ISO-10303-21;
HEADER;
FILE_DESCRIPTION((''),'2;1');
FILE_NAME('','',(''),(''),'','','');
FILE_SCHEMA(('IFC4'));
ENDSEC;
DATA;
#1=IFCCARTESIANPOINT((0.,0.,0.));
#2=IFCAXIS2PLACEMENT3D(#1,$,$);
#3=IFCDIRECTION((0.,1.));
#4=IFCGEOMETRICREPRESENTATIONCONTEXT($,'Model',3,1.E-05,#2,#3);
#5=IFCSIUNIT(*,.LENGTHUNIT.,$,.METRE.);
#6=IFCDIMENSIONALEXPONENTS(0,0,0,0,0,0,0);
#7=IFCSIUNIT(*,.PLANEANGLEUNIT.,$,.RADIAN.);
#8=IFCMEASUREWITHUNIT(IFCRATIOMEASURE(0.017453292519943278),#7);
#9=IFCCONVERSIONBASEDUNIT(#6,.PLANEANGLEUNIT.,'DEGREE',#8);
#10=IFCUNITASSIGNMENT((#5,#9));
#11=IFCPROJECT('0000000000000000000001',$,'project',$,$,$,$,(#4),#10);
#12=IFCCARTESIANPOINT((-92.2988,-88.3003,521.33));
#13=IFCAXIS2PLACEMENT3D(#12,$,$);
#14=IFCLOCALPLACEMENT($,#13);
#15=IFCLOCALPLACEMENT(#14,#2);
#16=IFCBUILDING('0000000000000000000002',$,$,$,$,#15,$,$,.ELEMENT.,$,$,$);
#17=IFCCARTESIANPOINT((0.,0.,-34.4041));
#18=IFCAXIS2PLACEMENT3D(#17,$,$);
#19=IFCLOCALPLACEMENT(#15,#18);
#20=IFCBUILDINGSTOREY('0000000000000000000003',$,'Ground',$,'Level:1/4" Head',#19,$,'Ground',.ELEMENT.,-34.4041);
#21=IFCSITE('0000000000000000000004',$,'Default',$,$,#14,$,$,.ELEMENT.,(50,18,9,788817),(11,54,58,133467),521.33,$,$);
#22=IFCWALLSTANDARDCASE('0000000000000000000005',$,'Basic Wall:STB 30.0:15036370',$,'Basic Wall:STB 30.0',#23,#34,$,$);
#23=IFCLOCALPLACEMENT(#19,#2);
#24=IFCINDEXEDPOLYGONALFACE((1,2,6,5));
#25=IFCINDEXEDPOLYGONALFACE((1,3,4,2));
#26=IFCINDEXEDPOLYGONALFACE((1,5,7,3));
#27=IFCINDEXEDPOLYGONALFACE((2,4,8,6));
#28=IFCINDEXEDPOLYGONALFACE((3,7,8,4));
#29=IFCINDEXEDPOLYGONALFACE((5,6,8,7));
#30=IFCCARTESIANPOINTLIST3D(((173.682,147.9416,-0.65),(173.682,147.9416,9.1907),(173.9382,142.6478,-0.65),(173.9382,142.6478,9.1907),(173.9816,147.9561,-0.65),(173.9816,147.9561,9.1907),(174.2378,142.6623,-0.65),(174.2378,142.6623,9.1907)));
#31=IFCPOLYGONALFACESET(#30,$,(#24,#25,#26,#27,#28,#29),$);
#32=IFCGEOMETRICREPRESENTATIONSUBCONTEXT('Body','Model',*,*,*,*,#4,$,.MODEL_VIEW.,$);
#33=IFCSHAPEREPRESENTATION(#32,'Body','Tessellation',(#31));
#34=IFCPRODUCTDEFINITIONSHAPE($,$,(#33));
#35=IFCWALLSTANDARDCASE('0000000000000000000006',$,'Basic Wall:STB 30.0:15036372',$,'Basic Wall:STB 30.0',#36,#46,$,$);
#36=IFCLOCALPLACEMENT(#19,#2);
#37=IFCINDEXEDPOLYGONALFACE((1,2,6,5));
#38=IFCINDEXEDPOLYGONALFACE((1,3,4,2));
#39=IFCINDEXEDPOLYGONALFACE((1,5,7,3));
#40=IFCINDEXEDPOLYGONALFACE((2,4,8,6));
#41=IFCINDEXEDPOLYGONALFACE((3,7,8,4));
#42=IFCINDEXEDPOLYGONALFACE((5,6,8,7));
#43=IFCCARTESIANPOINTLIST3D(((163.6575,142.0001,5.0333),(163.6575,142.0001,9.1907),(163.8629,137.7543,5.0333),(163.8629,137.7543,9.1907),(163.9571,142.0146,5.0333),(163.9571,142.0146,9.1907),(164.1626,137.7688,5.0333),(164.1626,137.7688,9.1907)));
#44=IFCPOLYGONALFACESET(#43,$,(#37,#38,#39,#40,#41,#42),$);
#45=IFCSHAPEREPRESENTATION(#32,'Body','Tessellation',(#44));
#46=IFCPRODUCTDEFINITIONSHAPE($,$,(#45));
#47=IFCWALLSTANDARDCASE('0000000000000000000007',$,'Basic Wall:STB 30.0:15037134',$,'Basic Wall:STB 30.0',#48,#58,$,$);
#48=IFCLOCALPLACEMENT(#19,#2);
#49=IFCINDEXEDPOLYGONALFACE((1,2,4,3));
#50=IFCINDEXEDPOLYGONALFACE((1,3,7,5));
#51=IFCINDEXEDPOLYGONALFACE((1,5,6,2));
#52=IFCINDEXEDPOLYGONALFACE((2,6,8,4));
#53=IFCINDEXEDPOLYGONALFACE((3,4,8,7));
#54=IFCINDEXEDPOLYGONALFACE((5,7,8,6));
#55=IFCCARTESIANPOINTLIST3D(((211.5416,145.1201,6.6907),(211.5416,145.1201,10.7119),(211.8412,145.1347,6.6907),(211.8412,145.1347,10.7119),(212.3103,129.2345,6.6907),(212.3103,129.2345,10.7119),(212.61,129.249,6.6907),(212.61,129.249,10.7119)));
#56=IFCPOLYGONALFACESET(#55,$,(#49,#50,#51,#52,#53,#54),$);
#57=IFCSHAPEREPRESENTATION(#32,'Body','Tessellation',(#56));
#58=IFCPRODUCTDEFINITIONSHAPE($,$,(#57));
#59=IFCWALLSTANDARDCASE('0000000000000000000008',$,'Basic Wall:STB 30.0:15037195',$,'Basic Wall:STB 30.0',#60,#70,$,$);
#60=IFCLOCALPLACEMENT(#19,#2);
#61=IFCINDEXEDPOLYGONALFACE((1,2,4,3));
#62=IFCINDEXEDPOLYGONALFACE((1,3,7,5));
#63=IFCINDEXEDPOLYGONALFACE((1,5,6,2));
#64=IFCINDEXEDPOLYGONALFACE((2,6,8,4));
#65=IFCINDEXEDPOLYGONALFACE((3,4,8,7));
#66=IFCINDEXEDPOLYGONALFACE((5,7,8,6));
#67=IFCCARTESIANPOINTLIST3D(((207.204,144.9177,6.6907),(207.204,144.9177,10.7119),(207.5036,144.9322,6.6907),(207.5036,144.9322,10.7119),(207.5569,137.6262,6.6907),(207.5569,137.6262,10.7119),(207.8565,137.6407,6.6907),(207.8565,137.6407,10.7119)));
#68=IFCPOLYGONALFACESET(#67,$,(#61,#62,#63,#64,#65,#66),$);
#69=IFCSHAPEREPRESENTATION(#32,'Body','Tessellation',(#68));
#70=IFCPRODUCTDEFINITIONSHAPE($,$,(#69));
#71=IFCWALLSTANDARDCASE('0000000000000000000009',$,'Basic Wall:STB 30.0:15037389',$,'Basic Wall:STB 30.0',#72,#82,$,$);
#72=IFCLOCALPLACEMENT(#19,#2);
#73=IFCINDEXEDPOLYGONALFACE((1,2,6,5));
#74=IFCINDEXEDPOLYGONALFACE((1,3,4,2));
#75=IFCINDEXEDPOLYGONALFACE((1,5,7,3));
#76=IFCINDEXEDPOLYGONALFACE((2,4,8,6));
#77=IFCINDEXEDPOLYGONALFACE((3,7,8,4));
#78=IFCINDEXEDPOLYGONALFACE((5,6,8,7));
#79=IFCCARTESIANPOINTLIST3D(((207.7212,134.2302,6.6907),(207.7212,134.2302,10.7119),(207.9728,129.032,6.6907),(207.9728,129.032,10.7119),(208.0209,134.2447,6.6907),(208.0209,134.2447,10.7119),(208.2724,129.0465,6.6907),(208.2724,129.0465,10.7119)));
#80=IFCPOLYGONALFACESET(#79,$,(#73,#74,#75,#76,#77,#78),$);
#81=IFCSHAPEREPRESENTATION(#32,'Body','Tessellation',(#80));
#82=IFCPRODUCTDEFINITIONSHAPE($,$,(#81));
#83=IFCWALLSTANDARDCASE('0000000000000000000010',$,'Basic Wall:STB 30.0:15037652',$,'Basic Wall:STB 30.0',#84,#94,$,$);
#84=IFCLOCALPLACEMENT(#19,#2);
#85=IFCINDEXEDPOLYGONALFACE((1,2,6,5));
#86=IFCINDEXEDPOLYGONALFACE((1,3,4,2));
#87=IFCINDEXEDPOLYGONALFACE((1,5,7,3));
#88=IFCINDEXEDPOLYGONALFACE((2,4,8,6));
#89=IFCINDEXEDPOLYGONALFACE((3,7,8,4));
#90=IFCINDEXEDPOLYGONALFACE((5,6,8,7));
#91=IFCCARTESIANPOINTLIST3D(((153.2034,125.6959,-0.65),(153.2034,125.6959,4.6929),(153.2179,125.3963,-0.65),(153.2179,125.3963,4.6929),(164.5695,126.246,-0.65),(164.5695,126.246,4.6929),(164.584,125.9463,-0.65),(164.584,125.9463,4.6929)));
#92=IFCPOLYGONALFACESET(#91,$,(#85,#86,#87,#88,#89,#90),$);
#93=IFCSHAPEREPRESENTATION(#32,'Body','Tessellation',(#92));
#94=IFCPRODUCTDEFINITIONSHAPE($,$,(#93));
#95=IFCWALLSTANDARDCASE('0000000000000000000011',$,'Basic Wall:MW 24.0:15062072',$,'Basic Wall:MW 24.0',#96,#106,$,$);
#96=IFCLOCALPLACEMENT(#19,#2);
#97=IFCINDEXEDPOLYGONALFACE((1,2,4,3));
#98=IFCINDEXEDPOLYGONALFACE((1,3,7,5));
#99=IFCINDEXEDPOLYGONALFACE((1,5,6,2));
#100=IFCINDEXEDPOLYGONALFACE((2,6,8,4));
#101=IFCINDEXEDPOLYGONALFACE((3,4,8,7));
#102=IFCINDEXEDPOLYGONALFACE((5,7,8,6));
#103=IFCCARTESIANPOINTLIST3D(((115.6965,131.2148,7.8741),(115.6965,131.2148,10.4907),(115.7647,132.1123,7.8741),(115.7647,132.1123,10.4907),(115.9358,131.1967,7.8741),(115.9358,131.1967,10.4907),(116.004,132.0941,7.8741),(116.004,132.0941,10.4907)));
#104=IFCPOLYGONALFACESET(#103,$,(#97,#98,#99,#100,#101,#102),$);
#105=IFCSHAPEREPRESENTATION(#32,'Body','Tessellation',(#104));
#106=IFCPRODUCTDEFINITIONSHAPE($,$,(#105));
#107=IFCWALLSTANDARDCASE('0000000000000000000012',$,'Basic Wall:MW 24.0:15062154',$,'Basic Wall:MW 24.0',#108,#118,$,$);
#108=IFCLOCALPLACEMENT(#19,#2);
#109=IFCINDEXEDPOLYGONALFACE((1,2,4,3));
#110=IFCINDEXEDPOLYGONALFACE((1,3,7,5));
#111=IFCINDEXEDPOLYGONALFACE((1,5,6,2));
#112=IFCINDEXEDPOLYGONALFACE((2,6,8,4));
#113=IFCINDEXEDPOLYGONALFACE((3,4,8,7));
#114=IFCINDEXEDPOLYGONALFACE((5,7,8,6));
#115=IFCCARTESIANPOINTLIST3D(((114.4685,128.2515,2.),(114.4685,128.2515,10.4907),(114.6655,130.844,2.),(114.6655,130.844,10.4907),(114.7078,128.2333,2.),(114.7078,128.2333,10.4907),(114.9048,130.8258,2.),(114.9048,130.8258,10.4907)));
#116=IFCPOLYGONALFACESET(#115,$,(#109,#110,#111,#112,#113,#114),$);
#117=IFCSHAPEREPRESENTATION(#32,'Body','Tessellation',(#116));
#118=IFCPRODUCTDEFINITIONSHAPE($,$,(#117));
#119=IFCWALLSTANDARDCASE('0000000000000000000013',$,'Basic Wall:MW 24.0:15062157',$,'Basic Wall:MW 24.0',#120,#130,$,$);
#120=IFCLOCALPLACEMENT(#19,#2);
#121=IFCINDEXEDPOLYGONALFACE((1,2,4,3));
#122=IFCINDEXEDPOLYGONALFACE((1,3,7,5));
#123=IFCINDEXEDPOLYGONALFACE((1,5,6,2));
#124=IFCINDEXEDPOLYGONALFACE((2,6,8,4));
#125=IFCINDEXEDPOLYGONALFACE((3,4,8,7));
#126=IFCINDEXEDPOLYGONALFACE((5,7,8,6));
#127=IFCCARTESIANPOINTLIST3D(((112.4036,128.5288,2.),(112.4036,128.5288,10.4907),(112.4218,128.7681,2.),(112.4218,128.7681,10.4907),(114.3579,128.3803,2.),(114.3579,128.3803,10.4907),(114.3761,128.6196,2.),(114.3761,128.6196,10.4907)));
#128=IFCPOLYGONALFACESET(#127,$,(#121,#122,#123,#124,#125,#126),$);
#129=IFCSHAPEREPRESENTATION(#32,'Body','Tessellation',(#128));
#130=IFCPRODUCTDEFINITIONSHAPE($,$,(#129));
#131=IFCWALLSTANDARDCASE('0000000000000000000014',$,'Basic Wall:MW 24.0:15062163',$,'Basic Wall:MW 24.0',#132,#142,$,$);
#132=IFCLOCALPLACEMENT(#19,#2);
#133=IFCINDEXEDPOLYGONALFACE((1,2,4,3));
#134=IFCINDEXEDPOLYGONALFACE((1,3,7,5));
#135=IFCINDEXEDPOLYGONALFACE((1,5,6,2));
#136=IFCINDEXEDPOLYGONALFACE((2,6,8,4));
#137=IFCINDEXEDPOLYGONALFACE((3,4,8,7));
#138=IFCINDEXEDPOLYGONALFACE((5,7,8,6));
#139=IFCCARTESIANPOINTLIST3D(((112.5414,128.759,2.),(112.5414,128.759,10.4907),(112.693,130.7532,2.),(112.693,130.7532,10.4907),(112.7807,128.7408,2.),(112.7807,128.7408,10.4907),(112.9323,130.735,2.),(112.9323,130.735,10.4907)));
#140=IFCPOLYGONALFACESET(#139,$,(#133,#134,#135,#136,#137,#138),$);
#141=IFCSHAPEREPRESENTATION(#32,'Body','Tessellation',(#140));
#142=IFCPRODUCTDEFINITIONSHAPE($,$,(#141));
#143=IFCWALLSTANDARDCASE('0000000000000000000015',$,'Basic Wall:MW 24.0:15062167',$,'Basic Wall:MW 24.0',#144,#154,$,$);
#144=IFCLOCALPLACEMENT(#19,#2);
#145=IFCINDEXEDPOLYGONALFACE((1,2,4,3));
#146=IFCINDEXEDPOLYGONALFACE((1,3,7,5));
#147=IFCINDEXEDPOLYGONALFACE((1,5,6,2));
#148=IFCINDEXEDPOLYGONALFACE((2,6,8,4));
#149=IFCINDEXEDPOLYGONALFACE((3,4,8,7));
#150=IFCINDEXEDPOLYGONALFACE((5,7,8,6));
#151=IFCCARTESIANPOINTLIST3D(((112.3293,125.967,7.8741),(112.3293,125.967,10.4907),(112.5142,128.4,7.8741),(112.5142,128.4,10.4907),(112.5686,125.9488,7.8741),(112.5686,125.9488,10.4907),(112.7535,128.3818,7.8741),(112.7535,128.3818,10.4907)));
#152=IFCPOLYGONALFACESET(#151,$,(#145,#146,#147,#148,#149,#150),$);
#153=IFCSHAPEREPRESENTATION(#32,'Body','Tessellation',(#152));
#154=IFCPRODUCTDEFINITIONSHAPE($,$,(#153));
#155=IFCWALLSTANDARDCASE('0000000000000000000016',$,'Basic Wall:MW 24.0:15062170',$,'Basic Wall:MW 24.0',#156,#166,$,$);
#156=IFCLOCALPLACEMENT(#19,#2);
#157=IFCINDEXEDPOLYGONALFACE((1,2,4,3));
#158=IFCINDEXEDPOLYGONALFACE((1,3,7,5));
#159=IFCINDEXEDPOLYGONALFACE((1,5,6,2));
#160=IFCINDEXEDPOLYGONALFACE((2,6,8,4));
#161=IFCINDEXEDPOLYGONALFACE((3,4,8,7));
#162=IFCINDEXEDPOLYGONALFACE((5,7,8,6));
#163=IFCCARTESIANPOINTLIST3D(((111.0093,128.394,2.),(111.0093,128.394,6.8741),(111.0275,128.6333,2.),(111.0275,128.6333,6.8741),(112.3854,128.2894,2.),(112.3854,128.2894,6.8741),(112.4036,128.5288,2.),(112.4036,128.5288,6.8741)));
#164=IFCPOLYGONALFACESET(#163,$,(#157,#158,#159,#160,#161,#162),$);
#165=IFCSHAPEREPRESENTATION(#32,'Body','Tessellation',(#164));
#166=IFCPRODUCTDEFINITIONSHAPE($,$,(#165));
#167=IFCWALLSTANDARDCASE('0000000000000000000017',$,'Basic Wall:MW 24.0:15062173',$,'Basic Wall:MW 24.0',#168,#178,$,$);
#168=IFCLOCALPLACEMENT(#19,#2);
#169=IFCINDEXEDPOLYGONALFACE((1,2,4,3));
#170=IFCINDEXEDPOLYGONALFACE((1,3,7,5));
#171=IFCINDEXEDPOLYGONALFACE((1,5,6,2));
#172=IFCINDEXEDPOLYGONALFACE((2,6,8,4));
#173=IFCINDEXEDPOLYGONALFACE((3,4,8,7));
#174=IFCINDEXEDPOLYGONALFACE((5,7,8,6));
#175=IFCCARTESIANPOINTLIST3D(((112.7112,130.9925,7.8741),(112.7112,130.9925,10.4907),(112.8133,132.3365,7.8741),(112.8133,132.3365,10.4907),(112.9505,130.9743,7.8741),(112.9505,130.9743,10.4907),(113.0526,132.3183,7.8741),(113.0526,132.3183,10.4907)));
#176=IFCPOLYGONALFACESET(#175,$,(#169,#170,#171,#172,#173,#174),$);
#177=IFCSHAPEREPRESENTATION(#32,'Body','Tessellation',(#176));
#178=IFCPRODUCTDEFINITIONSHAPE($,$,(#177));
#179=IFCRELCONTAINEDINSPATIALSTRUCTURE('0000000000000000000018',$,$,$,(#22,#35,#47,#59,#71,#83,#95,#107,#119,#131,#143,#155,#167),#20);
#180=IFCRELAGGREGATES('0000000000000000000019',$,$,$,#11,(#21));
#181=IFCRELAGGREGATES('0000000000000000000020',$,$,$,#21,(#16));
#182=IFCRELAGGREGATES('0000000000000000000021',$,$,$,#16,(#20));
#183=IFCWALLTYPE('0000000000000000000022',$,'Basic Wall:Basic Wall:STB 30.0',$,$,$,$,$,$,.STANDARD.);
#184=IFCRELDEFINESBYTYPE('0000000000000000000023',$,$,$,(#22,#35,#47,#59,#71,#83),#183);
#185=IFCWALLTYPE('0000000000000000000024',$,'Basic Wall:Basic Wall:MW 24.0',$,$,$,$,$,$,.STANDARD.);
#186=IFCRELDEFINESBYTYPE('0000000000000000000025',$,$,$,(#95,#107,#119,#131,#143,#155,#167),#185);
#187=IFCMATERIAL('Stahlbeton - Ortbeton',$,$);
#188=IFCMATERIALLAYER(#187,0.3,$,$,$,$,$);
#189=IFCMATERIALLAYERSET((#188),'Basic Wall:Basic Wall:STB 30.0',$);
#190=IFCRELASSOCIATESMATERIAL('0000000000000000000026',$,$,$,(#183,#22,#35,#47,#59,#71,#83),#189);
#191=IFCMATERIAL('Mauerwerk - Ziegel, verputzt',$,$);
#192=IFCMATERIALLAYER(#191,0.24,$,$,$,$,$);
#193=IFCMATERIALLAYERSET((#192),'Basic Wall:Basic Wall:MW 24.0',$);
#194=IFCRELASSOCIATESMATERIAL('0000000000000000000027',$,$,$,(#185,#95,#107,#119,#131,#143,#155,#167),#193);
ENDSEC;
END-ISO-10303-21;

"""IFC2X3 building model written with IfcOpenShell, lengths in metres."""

from ifc_helpers import new_model, entity, si_unit, converted_unit, direction, frame, frame_2d, origin, place, context, subcontext, project, spatial, rectangle, extrude, material, layer, layer_set, layer_usage, type_object, element, save


model = new_model("IFC2X3")

# Units and contexts
model_context = context("Model", 3, precision=1e-05, world=origin(), true_north=direction((0.0, 1.0)))
body_context = subcontext(model_context, "Body", "Model", "MODEL_VIEW")
ifc_project = project(units=[si_unit("LENGTHUNIT", "METRE"), converted_unit("PLANEANGLEUNIT", "DEGREE", entity("IfcRatioMeasure", 0.017453292519943278), si_unit("PLANEANGLEUNIT", "RADIAN"), dimensions=[0, 0, 0, 0, 0, 0, 0])], contexts=[model_context])

# Site, building, storey
site_placement = place(None, frame((-92.2988, -88.3003, 521.33)))
site = spatial("IfcSite", under=ifc_project, at=site_placement, Name="Default", CompositionType="ELEMENT", RefLatitude=(50, 18, 9, 788817), RefLongitude=(11, 54, 58, 133467), RefElevation=521.33)
building_placement = place(site_placement, origin())
building = spatial("IfcBuilding", under=site, at=building_placement, CompositionType="ELEMENT")
storey_placement = place(building_placement, frame((0.0, 0.0, -34.4041)))
storey = spatial("IfcBuildingStorey", under=building, at=storey_placement, Name="Ground", ObjectType="Level:1/4\" Head", LongName="Ground", CompositionType="ELEMENT", Elevation=-34.4041)

# Walls
ifc_material_1 = material(Name="Stahlbeton - Ortbeton")
ifc_layer_1 = layer(ifc_material_1, 0.3)
ifc_layer_set_1 = layer_set([ifc_layer_1], Name="Basic Wall:Basic Wall:STB 30.0")
wall_type_1 = type_object("IfcWallType", Name="Basic Wall:Basic Wall:STB 30.0", PredefinedType="STANDARD", material=ifc_layer_set_1)
ifc_layer_usage_1 = layer_usage(ifc_layer_set_1, "AXIS2", "NEGATIVE", 0.15)
wall_1_placement = place(storey_placement, frame((173.8318, 147.9489, -0.65), z_axis=(0.0, 0.0, 1.0), x_axis=(0.048337, -0.998831, 0.0)))
element("IfcWallStandardCase", 1, at=wall_1_placement, inside=storey, type_object=wall_type_1, material=ifc_layer_usage_1, Name="Basic Wall:STB 30.0:15036370", ObjectType="Basic Wall:STB 30.0", context=body_context, shape_type="SweptSolid", body=[
    extrude(rectangle(XDim=5.3, YDim=0.3, at=frame_2d((2.65, 0.0), x_axis=(-1.0, 0.0))), origin(), (0.0, 0.0, 1.0), 9.8407),
])
ifc_layer_usage_2 = layer_usage(ifc_layer_set_1, "AXIS2", "NEGATIVE", 0.15)
wall_2_placement = place(storey_placement, frame((163.8073, 142.0074, 5.0333), z_axis=(0.0, 0.0, 1.0), x_axis=(0.048337, -0.998831, 0.0)))
element("IfcWallStandardCase", 2, at=wall_2_placement, inside=storey, type_object=wall_type_1, material=ifc_layer_usage_2, Name="Basic Wall:STB 30.0:15036372", ObjectType="Basic Wall:STB 30.0", context=body_context, shape_type="SweptSolid", body=[
    extrude(rectangle(XDim=4.2508, YDim=0.3, at=frame_2d((2.1254, 0.0), x_axis=(-1.0, 0.0))), origin(), (0.0, 0.0, 1.0), 4.1574),
])
ifc_layer_usage_3 = layer_usage(ifc_layer_set_1, "AXIS2", "NEGATIVE", 0.15)
wall_3_placement = place(storey_placement, frame((211.6914, 145.1274, 6.6907), z_axis=(0.0, 0.0, 1.0), x_axis=(0.048337, -0.998831, 0.0)))
element("IfcWallStandardCase", 3, at=wall_3_placement, inside=storey, type_object=wall_type_1, material=ifc_layer_usage_3, Name="Basic Wall:STB 30.0:15037134", ObjectType="Basic Wall:STB 30.0", context=body_context, shape_type="SweptSolid", body=[
    extrude(rectangle(XDim=15.9043, YDim=0.3, at=frame_2d((7.9521, 0.0), x_axis=(-1.0, 0.0))), origin(), (0.0, 0.0, 1.0), 4.0212),
])
ifc_layer_usage_4 = layer_usage(ifc_layer_set_1, "AXIS2", "NEGATIVE", 0.15)
wall_4_placement = place(storey_placement, frame((207.3538, 144.9249, 6.6907), z_axis=(0.0, 0.0, 1.0), x_axis=(0.048337, -0.998831, 0.0)))
element("IfcWallStandardCase", 4, at=wall_4_placement, inside=storey, type_object=wall_type_1, material=ifc_layer_usage_4, Name="Basic Wall:STB 30.0:15037195", ObjectType="Basic Wall:STB 30.0", context=body_context, shape_type="SweptSolid", body=[
    extrude(rectangle(XDim=7.3, YDim=0.3, at=frame_2d((3.65, 0.0), x_axis=(-1.0, 0.0))), origin(), (0.0, 0.0, 1.0), 4.0212),
])
ifc_layer_usage_5 = layer_usage(ifc_layer_set_1, "AXIS2", "NEGATIVE", 0.15)
wall_5_placement = place(storey_placement, frame((207.871, 134.2374, 6.6907), z_axis=(0.0, 0.0, 1.0), x_axis=(0.048337, -0.998831, 0.0)))
element("IfcWallStandardCase", 5, at=wall_5_placement, inside=storey, type_object=wall_type_1, material=ifc_layer_usage_5, Name="Basic Wall:STB 30.0:15037389", ObjectType="Basic Wall:STB 30.0", context=body_context, shape_type="SweptSolid", body=[
    extrude(rectangle(XDim=5.2043, YDim=0.3, at=frame_2d((2.6021, 0.0), x_axis=(-1.0, 0.0))), origin(), (0.0, 0.0, 1.0), 4.0212),
])
ifc_layer_usage_6 = layer_usage(ifc_layer_set_1, "AXIS2", "NEGATIVE", 0.15)
wall_6_placement = place(storey_placement, frame((164.5768, 126.0962, -0.65), z_axis=(0.0, 0.0, 1.0), x_axis=(-0.998831, -0.048337, 0.0)))
element("IfcWallStandardCase", 6, at=wall_6_placement, inside=storey, type_object=wall_type_1, material=ifc_layer_usage_6, Name="Basic Wall:STB 30.0:15037652", ObjectType="Basic Wall:STB 30.0", context=body_context, shape_type="SweptSolid", body=[
    extrude(rectangle(XDim=11.3795, YDim=0.3, at=frame_2d((5.6897, 0.0), x_axis=(-1.0, 0.0))), origin(), (0.0, 0.0, 1.0), 5.3429),
])
ifc_material_2 = material(Name="Mauerwerk - Ziegel, verputzt")
ifc_layer_2 = layer(ifc_material_2, 0.24)
ifc_layer_set_2 = layer_set([ifc_layer_2], Name="Basic Wall:Basic Wall:MW 24.0")
ifc_layer_usage_7 = layer_usage(ifc_layer_set_2, "AXIS2", "NEGATIVE", 0.12)
wall_type_2 = type_object("IfcWallType", Name="Basic Wall:Basic Wall:MW 24.0", PredefinedType="STANDARD", material=ifc_layer_set_2)
wall_7_placement = place(storey_placement, frame((115.8844, 132.1032, 7.8741), z_axis=(0.0, 0.0, 1.0), x_axis=(-0.07577, -0.997125, 0.0)))
element("IfcWallStandardCase", 7, at=wall_7_placement, inside=storey, type_object=wall_type_2, material=ifc_layer_usage_7, Name="Basic Wall:MW 24.0:15062072", ObjectType="Basic Wall:MW 24.0", context=body_context, shape_type="SweptSolid", body=[
    extrude(rectangle(XDim=0.9, YDim=0.24, at=frame_2d((0.45, 0.0), x_axis=(-1.0, 0.0))), origin(), (0.0, 0.0, 1.0), 2.6166),
])
ifc_layer_usage_8 = layer_usage(ifc_layer_set_2, "AXIS2", "NEGATIVE", 0.12)
wall_8_placement = place(storey_placement, frame((114.5881, 128.2424, 2.0), z_axis=(0.0, 0.0, 1.0), x_axis=(0.07577, 0.997125, 0.0)))
element("IfcWallStandardCase", 8, at=wall_8_placement, inside=storey, type_object=wall_type_2, material=ifc_layer_usage_8, Name="Basic Wall:MW 24.0:15062154", ObjectType="Basic Wall:MW 24.0", context=body_context, shape_type="SweptSolid", body=[
    extrude(rectangle(XDim=2.6, YDim=0.24, at=frame_2d((1.3, 0.0), x_axis=(-1.0, 0.0))), origin(), (0.0, 0.0, 1.0), 8.4907),
])
ifc_layer_usage_9 = layer_usage(ifc_layer_set_2, "AXIS2", "NEGATIVE", 0.12)
wall_9_placement = place(storey_placement, frame((114.367, 128.4999, 2.0), z_axis=(0.0, 0.0, 1.0), x_axis=(-0.997125, 0.07577, 0.0)))
element("IfcWallStandardCase", 9, at=wall_9_placement, inside=storey, type_object=wall_type_2, material=ifc_layer_usage_9, Name="Basic Wall:MW 24.0:15062157", ObjectType="Basic Wall:MW 24.0", context=body_context, shape_type="SweptSolid", body=[
    extrude(rectangle(XDim=1.9599, YDim=0.24, at=frame_2d((0.98, 0.0), x_axis=(-1.0, 0.0))), origin(), (0.0, 0.0, 1.0), 8.4907),
])
ifc_layer_usage_10 = layer_usage(ifc_layer_set_2, "AXIS2", "NEGATIVE", 0.12)
wall_10_placement = place(storey_placement, frame((112.6611, 128.7499, 2.0), z_axis=(0.0, 0.0, 1.0), x_axis=(0.07577, 0.997125, 0.0)))
element("IfcWallStandardCase", 10, at=wall_10_placement, inside=storey, type_object=wall_type_2, material=ifc_layer_usage_10, Name="Basic Wall:MW 24.0:15062163", ObjectType="Basic Wall:MW 24.0", context=body_context, shape_type="SweptSolid", body=[
    extrude(rectangle(XDim=2.0, YDim=0.24, at=frame_2d((1.0, 0.0), x_axis=(-1.0, 0.0))), origin(), (0.0, 0.0, 1.0), 8.4907),
])
ifc_layer_usage_11 = layer_usage(ifc_layer_set_2, "AXIS2", "NEGATIVE", 0.12)
wall_11_placement = place(storey_placement, frame((112.4489, 125.9579, 7.8741), z_axis=(0.0, 0.0, 1.0), x_axis=(0.07577, 0.997125, 0.0)))
element("IfcWallStandardCase", 11, at=wall_11_placement, inside=storey, type_object=wall_type_2, material=ifc_layer_usage_11, Name="Basic Wall:MW 24.0:15062167", ObjectType="Basic Wall:MW 24.0", context=body_context, shape_type="SweptSolid", body=[
    extrude(rectangle(XDim=2.44, YDim=0.24, at=frame_2d((1.22, 0.0), x_axis=(-1.0, 0.0))), origin(), (0.0, 0.0, 1.0), 2.6166),
])
ifc_layer_usage_12 = layer_usage(ifc_layer_set_2, "AXIS2", "NEGATIVE", 0.12)
wall_12_placement = place(storey_placement, frame((111.0184, 128.5137, 2.0), z_axis=(0.0, 0.0, 1.0), x_axis=(0.997125, -0.07577, 0.0)))
element("IfcWallStandardCase", 12, at=wall_12_placement, inside=storey, type_object=wall_type_2, material=ifc_layer_usage_12, Name="Basic Wall:MW 24.0:15062170", ObjectType="Basic Wall:MW 24.0", context=body_context, shape_type="SweptSolid", body=[
    extrude(rectangle(XDim=1.3801, YDim=0.24, at=frame_2d((0.69, 0.0), x_axis=(-1.0, 0.0))), origin(), (0.0, 0.0, 1.0), 4.8741),
])
ifc_layer_usage_13 = layer_usage(ifc_layer_set_2, "AXIS2", "NEGATIVE", 0.12)
wall_13_placement = place(storey_placement, frame((112.8308, 130.9834, 7.8741), z_axis=(0.0, 0.0, 1.0), x_axis=(0.07577, 0.997125, 0.0)))
element("IfcWallStandardCase", 13, at=wall_13_placement, inside=storey, type_object=wall_type_2, material=ifc_layer_usage_13, Name="Basic Wall:MW 24.0:15062173", ObjectType="Basic Wall:MW 24.0", context=body_context, shape_type="SweptSolid", body=[
    extrude(rectangle(XDim=1.3479, YDim=0.24, at=frame_2d((0.6739, 0.0), x_axis=(-1.0, 0.0))), origin(), (0.0, 0.0, 1.0), 2.6166),
])

save(model, "model.ifc")
